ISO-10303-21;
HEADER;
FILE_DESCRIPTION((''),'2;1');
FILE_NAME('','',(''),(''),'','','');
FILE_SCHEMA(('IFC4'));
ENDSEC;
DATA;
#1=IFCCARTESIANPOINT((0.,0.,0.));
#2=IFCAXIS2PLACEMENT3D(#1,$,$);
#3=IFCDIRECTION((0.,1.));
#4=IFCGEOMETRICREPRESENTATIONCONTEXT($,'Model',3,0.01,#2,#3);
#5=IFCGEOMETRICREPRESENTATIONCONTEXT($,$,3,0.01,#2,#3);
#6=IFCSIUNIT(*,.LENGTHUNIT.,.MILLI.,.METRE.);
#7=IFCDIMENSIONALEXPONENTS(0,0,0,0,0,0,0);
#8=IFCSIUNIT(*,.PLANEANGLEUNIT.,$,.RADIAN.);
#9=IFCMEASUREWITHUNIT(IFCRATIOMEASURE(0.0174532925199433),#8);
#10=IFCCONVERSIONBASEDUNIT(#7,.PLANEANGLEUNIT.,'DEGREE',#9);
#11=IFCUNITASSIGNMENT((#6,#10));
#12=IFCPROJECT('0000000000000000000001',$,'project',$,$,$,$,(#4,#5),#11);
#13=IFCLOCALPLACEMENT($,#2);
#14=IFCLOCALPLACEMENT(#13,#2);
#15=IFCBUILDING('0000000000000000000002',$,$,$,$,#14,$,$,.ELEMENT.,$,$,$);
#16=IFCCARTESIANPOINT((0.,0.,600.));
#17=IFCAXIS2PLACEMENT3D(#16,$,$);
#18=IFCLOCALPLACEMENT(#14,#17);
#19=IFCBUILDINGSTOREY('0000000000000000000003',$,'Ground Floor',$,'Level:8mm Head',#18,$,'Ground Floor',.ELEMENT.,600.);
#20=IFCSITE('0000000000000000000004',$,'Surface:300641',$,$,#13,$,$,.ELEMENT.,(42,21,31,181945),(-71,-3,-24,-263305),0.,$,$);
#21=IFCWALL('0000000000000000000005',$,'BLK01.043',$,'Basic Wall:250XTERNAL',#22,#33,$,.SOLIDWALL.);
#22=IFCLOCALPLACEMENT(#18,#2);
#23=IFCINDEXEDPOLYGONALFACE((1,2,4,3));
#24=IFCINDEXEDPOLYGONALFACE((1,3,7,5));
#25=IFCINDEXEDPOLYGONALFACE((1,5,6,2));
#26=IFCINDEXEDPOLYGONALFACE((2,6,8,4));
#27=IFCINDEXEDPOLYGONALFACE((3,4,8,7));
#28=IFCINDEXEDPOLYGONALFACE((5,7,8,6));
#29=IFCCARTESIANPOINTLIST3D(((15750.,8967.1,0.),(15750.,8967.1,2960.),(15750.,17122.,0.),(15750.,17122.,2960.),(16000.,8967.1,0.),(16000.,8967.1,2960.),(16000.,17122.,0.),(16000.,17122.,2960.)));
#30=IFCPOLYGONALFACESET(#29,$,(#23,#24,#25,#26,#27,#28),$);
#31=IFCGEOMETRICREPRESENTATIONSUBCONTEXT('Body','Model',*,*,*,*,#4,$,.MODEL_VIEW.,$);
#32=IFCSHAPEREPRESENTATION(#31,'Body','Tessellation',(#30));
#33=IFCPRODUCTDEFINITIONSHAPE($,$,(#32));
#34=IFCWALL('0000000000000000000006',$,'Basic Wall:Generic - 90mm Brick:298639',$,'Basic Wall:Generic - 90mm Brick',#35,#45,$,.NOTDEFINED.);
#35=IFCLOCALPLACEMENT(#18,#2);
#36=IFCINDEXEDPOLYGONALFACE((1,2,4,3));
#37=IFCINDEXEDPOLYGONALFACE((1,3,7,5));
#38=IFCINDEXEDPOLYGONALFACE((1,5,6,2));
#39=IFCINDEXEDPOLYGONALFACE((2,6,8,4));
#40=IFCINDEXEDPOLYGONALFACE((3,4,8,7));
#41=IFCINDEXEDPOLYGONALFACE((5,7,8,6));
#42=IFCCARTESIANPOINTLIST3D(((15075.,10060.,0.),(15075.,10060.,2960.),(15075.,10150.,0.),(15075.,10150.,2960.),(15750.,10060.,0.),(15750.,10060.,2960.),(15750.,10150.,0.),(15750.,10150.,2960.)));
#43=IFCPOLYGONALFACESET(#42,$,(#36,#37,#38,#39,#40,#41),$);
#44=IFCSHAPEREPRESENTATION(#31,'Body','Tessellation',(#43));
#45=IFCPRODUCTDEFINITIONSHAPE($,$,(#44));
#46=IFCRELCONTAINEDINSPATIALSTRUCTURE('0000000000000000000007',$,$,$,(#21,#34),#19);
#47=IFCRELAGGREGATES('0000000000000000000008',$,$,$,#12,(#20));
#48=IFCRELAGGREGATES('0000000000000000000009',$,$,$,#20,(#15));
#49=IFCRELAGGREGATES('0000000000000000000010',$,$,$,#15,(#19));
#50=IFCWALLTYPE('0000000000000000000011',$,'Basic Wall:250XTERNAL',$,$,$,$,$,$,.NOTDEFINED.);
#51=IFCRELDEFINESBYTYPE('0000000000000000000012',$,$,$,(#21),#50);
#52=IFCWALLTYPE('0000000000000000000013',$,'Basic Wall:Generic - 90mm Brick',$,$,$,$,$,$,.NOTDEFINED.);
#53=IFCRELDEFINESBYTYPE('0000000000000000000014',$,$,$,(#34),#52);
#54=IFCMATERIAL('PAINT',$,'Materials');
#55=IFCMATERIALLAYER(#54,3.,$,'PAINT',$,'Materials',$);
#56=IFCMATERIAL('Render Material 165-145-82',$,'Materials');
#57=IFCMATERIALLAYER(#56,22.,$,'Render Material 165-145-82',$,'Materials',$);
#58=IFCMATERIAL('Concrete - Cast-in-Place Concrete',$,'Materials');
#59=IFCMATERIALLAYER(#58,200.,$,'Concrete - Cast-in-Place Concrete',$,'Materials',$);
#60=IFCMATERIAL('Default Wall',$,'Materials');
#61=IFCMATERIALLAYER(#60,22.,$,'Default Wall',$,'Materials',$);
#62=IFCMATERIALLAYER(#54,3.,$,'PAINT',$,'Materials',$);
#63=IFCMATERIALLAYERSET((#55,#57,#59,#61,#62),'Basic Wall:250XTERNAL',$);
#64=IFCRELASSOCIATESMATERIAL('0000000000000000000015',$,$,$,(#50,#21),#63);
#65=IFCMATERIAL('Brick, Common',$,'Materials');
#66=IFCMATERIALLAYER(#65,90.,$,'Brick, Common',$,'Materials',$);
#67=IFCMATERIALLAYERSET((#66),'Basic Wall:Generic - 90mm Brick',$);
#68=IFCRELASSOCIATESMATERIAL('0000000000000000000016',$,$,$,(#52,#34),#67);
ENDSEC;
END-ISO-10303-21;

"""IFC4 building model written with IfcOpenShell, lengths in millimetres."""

from ifc_helpers import new_model, entity, si_unit, converted_unit, direction, frame, frame_2d, origin, place, context, subcontext, project, spatial, polyline, rectangle, extrude, clip, halfspace, bounded_halfspace, material, layer, layer_set, layer_usage, type_object, element, save


model = new_model("IFC4")

# Units and contexts
model_context = context("Model", 3, precision=0.01, world=origin(), true_north=direction((0.0, 1.0)))
context_of_model = context(None, 3, precision=0.01, world=origin(), true_north=direction((0.0, 1.0)))
body_context = subcontext(model_context, "Body", "Model", "MODEL_VIEW")
ifc_project = project(units=[si_unit("LENGTHUNIT", "METRE", prefix="MILLI"), converted_unit("PLANEANGLEUNIT", "DEGREE", entity("IfcRatioMeasure", 0.0174532925199433), si_unit("PLANEANGLEUNIT", "RADIAN"), dimensions=[0, 0, 0, 0, 0, 0, 0])], contexts=[model_context, context_of_model])

# Site, building, storey
site_placement = place(None, origin())
site = spatial("IfcSite", under=ifc_project, at=site_placement, Name="Surface:300641", CompositionType="ELEMENT", RefLatitude=(42, 21, 31, 181945), RefLongitude=(-71, -3, -24, -263305), RefElevation=0.0)
building_placement = place(site_placement, origin())
building = spatial("IfcBuilding", under=site, at=building_placement, CompositionType="ELEMENT")
storey_placement = place(building_placement, frame((0.0, 0.0, 600.0)))
storey = spatial("IfcBuildingStorey", under=building, at=storey_placement, Name="Ground Floor", ObjectType="Level:8mm Head", LongName="Ground Floor", CompositionType="ELEMENT", Elevation=600.0)

# Shared definitions
ifc_material_1 = material(Name="PAINT", Category="Materials")
ifc_layer_1 = layer(ifc_material_1, 3.0, Name="PAINT", Category="Materials")
ifc_material_2 = material(Name="Render Material 165-145-82", Category="Materials")
ifc_layer_2 = layer(ifc_material_2, 22.0, Name="Render Material 165-145-82", Category="Materials")
ifc_material_3 = material(Name="Concrete - Cast-in-Place Concrete", Category="Materials")
ifc_layer_3 = layer(ifc_material_3, 200.0, Name="Concrete - Cast-in-Place Concrete", Category="Materials")
ifc_material_4 = material(Name="Default Wall", Category="Materials")
ifc_layer_4 = layer(ifc_material_4, 22.0, Name="Default Wall", Category="Materials")
ifc_layer_5 = layer(ifc_material_1, 3.0, Name="PAINT", Category="Materials")
ifc_layer_set_1 = layer_set([ifc_layer_1, ifc_layer_2, ifc_layer_3, ifc_layer_4, ifc_layer_5], Name="Basic Wall:250XTERNAL")
wall_type_1 = type_object("IfcWallType", Name="Basic Wall:250XTERNAL", PredefinedType="NOTDEFINED", material=ifc_layer_set_1)

# Walls
ifc_layer_usage_1 = layer_usage(ifc_layer_set_1, "AXIS2", "NEGATIVE", 125.0)
wall_1_placement = place(storey_placement, frame((15875.0, 8967.1, 0.0), z_axis=(0.0, 0.0, 1.0), x_axis=(0.0, 1.0, 0.0)))
element("IfcWall", 1, at=wall_1_placement, inside=storey, type_object=wall_type_1, material=ifc_layer_usage_1, Name="BLK01.043", ObjectType="Basic Wall:250XTERNAL", PredefinedType="SOLIDWALL", context=body_context, shape_type="Clipping", body=[
    clip(extrude(rectangle(XDim=8154.9, YDim=250.0, at=frame_2d((4077.5, 0.0), x_axis=(-1.0, 0.0))), origin(), (0.0, 0.0, 1.0), 2960.0), bounded_halfspace(frame((0.0, -125.0, 2960.0), z_axis=(0.0, 0.0, -1.0), x_axis=(-1.0, 0.0, 0.0)), True, frame((0.0, -125.0, 2960.0)), polyline([(0.0, 0.0), (8154.9, 0.0), (8154.9, 250.0), (3042.9, 250.0), (2792.9, 250.0), (1182.9, 250.0), (1092.9, 250.0), (0.0, 250.0), (0.0, 0.0)]))),
])
ifc_material_5 = material(Name="Brick, Common", Category="Materials")
ifc_layer_6 = layer(ifc_material_5, 90.0, Name="Brick, Common", Category="Materials")
ifc_layer_set_2 = layer_set([ifc_layer_6], Name="Basic Wall:Generic - 90mm Brick")
ifc_layer_usage_2 = layer_usage(ifc_layer_set_2, "AXIS2", "NEGATIVE", 45.0)
wall_type_2 = type_object("IfcWallType", Name="Basic Wall:Generic - 90mm Brick", PredefinedType="NOTDEFINED", material=ifc_layer_set_2)
wall_2_placement = place(storey_placement, frame((15075.0, 10105.0, 0.0)))
element("IfcWall", 2, at=wall_2_placement, inside=storey, type_object=wall_type_2, material=ifc_layer_usage_2, Name="Basic Wall:Generic - 90mm Brick:298639", ObjectType="Basic Wall:Generic - 90mm Brick", PredefinedType="NOTDEFINED", context=body_context, shape_type="Clipping", body=[
    clip(clip(extrude(rectangle(XDim=675.0, YDim=90.0, at=frame_2d((337.5, 0.0), x_axis=(-1.0, 0.0))), origin(), (0.0, 0.0, 1.0), 2960.0), bounded_halfspace(frame((0.0, -45.0, 2960.0), z_axis=(0.0, 0.0, -1.0), x_axis=(0.0, -1.0, 0.0)), True, frame((0.0, -45.0, 2960.0)), polyline([(0.0, 0.0), (675.0, 0.0), (675.0, 90.0), (0.0, 90.0), (0.0, 0.0)]))), halfspace(origin(), True)),
])

save(model, "model.ifc")
